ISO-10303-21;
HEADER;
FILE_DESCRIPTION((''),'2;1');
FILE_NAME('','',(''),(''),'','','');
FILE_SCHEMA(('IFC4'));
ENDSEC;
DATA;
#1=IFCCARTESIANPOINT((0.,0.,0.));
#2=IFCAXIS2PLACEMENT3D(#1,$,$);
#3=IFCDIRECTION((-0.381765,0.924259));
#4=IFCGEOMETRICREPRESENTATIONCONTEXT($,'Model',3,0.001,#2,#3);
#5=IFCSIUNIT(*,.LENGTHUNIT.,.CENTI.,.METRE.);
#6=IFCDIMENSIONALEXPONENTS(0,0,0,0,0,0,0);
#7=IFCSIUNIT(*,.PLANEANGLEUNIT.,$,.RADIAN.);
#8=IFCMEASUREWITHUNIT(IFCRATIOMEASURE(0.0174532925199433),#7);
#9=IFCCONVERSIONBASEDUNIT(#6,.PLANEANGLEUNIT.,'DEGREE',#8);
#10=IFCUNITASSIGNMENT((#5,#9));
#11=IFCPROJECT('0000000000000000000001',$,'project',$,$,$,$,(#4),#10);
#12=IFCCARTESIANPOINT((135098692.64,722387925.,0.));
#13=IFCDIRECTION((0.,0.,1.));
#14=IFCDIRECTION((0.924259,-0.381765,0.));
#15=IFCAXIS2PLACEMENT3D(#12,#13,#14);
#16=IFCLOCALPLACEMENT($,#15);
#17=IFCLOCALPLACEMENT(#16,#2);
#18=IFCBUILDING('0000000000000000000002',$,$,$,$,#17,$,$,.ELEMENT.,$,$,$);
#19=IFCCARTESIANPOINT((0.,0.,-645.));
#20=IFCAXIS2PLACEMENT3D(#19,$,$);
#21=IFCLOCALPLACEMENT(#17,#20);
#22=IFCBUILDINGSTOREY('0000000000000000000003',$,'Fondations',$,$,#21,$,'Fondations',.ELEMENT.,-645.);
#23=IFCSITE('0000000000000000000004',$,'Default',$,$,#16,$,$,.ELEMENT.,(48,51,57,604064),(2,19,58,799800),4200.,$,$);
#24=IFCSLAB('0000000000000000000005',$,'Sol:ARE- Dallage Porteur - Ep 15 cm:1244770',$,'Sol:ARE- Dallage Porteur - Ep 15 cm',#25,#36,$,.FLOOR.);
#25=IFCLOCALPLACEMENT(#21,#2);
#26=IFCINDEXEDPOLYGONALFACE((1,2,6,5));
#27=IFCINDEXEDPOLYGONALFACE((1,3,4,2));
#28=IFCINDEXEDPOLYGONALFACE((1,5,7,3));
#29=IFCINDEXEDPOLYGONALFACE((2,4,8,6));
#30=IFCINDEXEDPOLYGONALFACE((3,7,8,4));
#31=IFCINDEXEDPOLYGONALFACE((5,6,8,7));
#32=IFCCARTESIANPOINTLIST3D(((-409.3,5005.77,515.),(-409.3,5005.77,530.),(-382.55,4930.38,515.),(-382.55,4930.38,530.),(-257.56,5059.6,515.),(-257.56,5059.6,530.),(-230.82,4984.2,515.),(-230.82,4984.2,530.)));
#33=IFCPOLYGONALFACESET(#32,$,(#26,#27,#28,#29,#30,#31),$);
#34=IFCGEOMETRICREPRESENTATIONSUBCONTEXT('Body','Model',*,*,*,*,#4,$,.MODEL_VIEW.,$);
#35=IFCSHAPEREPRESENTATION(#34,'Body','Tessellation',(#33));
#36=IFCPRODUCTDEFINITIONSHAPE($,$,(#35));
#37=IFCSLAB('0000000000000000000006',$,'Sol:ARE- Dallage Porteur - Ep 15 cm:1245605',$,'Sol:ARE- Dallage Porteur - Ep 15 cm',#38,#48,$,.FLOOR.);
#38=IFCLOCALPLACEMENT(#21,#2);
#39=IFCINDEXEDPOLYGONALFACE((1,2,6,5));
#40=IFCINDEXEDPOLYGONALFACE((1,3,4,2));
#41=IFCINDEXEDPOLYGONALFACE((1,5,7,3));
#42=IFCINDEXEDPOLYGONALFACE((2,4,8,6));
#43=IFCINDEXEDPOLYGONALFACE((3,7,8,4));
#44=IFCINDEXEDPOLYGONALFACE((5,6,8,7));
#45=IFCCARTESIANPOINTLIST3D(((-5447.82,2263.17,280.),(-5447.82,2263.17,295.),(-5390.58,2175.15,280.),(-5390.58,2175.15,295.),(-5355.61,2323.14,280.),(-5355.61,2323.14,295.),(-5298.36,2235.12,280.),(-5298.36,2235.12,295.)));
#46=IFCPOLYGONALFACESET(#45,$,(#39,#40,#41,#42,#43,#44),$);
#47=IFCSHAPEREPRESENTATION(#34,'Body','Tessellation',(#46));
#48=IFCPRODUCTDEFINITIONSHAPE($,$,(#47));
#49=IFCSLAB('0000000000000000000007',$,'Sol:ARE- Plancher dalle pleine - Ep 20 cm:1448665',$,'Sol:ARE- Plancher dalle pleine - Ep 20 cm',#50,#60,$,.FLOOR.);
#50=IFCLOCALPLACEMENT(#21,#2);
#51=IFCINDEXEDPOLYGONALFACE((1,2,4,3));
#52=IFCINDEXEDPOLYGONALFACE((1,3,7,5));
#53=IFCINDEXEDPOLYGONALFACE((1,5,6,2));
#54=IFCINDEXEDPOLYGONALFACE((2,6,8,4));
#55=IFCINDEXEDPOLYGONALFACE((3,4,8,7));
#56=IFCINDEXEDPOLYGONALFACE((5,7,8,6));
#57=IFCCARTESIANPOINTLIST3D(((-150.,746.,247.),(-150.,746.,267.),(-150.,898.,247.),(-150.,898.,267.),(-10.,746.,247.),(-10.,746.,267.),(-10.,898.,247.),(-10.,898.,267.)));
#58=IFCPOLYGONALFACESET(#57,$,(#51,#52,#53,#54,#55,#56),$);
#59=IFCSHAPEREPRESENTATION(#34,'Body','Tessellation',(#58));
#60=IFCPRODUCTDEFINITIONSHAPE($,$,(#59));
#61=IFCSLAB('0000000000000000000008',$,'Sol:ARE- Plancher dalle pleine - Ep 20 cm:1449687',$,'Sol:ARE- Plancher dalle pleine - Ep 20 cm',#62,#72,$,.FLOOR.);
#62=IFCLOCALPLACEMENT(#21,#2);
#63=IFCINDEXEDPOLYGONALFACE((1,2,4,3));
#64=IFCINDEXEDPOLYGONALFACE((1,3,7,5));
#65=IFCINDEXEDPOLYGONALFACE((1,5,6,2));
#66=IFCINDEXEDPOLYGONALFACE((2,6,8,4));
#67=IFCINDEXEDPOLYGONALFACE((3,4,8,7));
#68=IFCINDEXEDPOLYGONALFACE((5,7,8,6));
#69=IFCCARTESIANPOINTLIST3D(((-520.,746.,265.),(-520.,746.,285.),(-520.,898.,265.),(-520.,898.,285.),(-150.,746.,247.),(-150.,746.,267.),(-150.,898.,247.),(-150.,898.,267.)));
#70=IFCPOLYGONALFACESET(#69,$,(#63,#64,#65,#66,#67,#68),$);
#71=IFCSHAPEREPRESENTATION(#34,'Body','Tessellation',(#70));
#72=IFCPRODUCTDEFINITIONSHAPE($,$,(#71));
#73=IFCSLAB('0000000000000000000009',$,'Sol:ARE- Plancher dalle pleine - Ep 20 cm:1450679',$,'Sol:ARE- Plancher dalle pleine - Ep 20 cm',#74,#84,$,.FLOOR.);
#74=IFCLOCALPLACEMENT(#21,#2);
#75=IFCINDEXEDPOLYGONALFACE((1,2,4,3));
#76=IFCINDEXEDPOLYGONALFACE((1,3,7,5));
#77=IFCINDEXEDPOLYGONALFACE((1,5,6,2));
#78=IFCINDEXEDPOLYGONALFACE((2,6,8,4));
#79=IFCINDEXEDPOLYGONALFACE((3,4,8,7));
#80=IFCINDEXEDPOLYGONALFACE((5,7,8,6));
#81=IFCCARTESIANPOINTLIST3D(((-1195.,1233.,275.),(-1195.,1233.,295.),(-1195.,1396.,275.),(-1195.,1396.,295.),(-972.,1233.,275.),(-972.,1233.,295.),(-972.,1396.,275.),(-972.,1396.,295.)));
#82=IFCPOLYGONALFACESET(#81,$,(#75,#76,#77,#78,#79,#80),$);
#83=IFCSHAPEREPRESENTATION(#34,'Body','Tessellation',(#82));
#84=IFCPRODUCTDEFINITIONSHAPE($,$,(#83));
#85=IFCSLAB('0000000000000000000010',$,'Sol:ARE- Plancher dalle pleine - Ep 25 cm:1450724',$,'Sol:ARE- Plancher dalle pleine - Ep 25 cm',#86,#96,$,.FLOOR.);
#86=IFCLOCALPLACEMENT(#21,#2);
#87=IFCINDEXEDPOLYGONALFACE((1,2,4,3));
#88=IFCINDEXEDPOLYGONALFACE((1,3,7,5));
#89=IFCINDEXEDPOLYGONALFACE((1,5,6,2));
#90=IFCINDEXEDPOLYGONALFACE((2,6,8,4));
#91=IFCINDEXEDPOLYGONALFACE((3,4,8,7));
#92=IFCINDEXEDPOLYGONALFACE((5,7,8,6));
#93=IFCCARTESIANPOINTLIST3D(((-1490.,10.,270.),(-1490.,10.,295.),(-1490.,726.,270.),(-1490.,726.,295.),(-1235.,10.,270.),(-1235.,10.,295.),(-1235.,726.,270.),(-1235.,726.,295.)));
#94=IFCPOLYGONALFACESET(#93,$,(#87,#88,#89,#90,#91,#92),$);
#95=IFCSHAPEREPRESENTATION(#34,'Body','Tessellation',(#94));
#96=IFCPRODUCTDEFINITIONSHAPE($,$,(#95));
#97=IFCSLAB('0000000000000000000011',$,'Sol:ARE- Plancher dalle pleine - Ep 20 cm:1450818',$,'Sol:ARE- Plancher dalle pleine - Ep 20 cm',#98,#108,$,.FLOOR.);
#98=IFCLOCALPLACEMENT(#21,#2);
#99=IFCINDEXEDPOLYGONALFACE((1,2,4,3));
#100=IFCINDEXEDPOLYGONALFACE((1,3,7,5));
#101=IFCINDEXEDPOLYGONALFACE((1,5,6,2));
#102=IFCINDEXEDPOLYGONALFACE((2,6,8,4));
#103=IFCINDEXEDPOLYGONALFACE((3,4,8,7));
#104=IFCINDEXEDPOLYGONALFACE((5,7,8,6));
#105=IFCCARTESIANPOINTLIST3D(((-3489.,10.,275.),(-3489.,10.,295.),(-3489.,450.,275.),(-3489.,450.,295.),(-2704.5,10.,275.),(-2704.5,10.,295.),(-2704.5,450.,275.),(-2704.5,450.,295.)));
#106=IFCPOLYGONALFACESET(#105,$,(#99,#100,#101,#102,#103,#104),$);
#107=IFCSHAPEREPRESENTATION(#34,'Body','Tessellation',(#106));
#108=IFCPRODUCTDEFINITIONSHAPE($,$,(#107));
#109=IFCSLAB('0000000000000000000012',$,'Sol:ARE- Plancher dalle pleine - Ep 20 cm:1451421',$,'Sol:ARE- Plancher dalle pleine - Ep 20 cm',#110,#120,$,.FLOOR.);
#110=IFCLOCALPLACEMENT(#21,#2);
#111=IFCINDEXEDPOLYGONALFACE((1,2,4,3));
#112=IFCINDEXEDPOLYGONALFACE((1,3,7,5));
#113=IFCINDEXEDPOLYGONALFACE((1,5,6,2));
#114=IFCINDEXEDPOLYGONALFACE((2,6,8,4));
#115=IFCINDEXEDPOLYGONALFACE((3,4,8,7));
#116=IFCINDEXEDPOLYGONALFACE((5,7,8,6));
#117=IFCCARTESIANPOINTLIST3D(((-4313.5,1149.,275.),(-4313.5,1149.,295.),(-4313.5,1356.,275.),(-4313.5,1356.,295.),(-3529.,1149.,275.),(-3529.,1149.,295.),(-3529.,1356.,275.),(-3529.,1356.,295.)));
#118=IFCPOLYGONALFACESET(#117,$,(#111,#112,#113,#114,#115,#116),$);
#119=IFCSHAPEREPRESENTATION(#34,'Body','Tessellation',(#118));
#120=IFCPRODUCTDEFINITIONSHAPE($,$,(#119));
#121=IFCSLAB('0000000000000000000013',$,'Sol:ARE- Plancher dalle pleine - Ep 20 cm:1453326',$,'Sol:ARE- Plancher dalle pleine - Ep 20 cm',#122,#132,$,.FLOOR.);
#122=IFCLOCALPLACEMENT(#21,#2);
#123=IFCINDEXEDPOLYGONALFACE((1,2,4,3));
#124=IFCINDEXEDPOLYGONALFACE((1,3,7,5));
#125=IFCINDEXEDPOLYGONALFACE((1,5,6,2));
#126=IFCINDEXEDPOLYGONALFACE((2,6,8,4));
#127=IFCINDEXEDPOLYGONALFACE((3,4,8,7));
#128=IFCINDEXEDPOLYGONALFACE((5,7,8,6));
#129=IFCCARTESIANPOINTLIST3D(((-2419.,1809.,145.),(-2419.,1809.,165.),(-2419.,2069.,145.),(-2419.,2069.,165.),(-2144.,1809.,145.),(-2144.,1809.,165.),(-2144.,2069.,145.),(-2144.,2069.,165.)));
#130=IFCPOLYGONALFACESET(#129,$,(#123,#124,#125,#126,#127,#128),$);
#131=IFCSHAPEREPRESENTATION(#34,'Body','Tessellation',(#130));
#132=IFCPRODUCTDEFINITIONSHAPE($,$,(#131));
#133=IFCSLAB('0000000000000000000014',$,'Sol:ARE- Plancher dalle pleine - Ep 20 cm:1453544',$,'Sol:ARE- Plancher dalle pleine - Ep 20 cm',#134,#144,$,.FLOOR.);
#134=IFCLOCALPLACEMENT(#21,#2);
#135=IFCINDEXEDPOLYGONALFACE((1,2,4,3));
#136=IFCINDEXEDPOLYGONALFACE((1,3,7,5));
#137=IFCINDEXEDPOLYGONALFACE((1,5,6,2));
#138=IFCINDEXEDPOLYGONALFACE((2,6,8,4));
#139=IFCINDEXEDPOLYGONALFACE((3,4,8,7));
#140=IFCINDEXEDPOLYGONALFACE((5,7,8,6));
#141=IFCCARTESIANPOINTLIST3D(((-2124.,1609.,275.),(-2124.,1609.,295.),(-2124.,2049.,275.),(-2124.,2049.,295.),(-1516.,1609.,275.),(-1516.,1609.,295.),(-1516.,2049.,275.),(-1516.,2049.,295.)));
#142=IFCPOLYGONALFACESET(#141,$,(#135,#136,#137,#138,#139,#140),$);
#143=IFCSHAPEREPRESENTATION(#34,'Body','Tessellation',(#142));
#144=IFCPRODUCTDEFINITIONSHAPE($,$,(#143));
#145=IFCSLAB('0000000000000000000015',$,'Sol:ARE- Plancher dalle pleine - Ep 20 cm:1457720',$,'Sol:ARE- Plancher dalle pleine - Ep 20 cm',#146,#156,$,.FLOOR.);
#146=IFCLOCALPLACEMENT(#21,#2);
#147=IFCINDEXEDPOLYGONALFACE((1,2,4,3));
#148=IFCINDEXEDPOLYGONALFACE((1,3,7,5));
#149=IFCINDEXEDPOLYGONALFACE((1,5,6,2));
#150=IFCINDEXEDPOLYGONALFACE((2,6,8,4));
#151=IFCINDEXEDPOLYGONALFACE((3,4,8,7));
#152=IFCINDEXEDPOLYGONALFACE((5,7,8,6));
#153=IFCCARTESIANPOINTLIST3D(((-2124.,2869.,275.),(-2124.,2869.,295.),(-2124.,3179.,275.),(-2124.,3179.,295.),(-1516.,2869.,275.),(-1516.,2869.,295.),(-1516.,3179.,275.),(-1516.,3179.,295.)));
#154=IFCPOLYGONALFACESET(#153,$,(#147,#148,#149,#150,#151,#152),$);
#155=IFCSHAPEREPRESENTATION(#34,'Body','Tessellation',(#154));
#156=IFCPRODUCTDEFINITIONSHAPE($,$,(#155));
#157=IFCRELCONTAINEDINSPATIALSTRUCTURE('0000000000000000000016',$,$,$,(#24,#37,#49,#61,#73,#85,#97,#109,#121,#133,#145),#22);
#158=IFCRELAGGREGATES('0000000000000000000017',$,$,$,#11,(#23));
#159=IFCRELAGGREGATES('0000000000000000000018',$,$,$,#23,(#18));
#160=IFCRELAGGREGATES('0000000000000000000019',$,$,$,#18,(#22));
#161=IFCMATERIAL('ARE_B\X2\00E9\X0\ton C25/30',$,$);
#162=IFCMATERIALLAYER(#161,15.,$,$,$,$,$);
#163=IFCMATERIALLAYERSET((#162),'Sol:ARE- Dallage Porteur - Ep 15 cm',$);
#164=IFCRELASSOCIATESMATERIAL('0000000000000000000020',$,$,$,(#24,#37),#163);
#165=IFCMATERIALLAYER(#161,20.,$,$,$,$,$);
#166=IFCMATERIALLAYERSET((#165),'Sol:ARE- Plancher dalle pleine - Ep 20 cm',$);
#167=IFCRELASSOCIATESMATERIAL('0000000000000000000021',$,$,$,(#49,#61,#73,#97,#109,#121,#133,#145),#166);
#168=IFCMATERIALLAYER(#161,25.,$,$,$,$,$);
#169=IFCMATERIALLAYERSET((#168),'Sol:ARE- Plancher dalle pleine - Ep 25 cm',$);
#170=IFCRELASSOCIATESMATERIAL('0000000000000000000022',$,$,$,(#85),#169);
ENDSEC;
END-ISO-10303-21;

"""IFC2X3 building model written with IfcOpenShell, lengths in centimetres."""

from ifc_helpers import new_model, entity, si_unit, converted_unit, direction, frame, frame_2d, origin, origin_2d_with_axis, place, context, subcontext, project, spatial, rectangle, extrude, clip, halfspace, material, layer, layer_set, layer_usage, element, save


model = new_model("IFC2X3")

# Units and contexts
model_context = context("Model", 3, precision=0.001, world=origin(), true_north=direction((-0.381765, 0.924259)))
body_context = subcontext(model_context, "Body", "Model", "MODEL_VIEW")
ifc_project = project(units=[si_unit("LENGTHUNIT", "METRE", prefix="CENTI"), converted_unit("PLANEANGLEUNIT", "DEGREE", entity("IfcRatioMeasure", 0.0174532925199433), si_unit("PLANEANGLEUNIT", "RADIAN"), dimensions=[0, 0, 0, 0, 0, 0, 0])], contexts=[model_context])

# Site, building, storey
site_placement = place(None, frame((135098692.64, 722387925.0, 0.0), z_axis=(0.0, 0.0, 1.0), x_axis=(0.924259, -0.381765, 0.0)))
site = spatial("IfcSite", under=ifc_project, at=site_placement, Name="Default", CompositionType="ELEMENT", RefLatitude=(48, 51, 57, 604064), RefLongitude=(2, 19, 58, 799800), RefElevation=4200.0)
building_placement = place(site_placement, origin())
building = spatial("IfcBuilding", under=site, at=building_placement, CompositionType="ELEMENT")
storey_placement = place(building_placement, frame((0.0, 0.0, -645.0)))
storey = spatial("IfcBuildingStorey", under=building, at=storey_placement, Name="Fondations", LongName="Fondations", CompositionType="ELEMENT", Elevation=-645.0)

# Slabs
ifc_material = material(Name="ARE_Béton C25/30")
ifc_layer_1 = layer(ifc_material, 15.0)
ifc_layer_set_1 = layer_set([ifc_layer_1], Name="Sol:ARE- Dallage Porteur - Ep 15 cm")
ifc_layer_usage_1 = layer_usage(ifc_layer_set_1, "AXIS3", "POSITIVE", 0.0)
slab_1_placement = place(storey_placement, origin())
element("IfcSlab", 1, at=slab_1_placement, inside=storey, material=ifc_layer_usage_1, Name="Sol:ARE- Dallage Porteur - Ep 15 cm:1244770", ObjectType="Sol:ARE- Dallage Porteur - Ep 15 cm", PredefinedType="FLOOR", context=body_context, shape_type="SweptSolid", body=[
    extrude(rectangle(XDim=80.0, YDim=161.0, at=frame_2d((0.0, 0.0), x_axis=(1.0, 0.0))), frame((-320.06, 4994.99, 530.0), z_axis=(0.0, 0.0, -1.0), x_axis=(0.334331, -0.942456, 0.0)), (0.0, 0.0, 1.0), 15.0),
])
ifc_layer_usage_2 = layer_usage(ifc_layer_set_1, "AXIS3", "POSITIVE", 0.0)
slab_2_placement = place(storey_placement, origin())
element("IfcSlab", 2, at=slab_2_placement, inside=storey, material=ifc_layer_usage_2, Name="Sol:ARE- Dallage Porteur - Ep 15 cm:1245605", ObjectType="Sol:ARE- Dallage Porteur - Ep 15 cm", PredefinedType="FLOOR", context=body_context, shape_type="SweptSolid", body=[
    extrude(rectangle(XDim=105.0, YDim=110.0, at=origin_2d_with_axis()), frame((-5373.09, 2249.14, 295.0), z_axis=(0.0, 0.0, -1.0), x_axis=(0.545236, -0.838282, 0.0)), (0.0, 0.0, 1.0), 15.0),
])
ifc_layer_2 = layer(ifc_material, 20.0)
ifc_layer_set_2 = layer_set([ifc_layer_2], Name="Sol:ARE- Plancher dalle pleine - Ep 20 cm")
ifc_layer_usage_3 = layer_usage(ifc_layer_set_2, "AXIS3", "POSITIVE", 0.0)
slab_3_placement = place(storey_placement, origin())
element("IfcSlab", 3, at=slab_3_placement, inside=storey, material=ifc_layer_usage_3, Name="Sol:ARE- Plancher dalle pleine - Ep 20 cm:1448665", ObjectType="Sol:ARE- Plancher dalle pleine - Ep 20 cm", PredefinedType="FLOOR", context=body_context, shape_type="SweptSolid", body=[
    extrude(rectangle(XDim=152.0, YDim=140.0, at=frame_2d((0.0, 0.0), x_axis=(1.0, 0.0))), frame((-80.0, 822.0, 267.0), z_axis=(0.0, 0.0, -1.0), x_axis=(0.0, 1.0, 0.0)), (0.0, 0.0, 1.0), 20.0),
])
ifc_layer_usage_4 = layer_usage(ifc_layer_set_2, "AXIS3", "POSITIVE", 0.0)
slab_4_placement = place(storey_placement, origin())
element("IfcSlab", 4, at=slab_4_placement, inside=storey, material=ifc_layer_usage_4, Name="Sol:ARE- Plancher dalle pleine - Ep 20 cm:1449687", ObjectType="Sol:ARE- Plancher dalle pleine - Ep 20 cm", PredefinedType="FLOOR", context=body_context, shape_type="Clipping", body=[
    clip(clip(extrude(rectangle(XDim=370.44, YDim=152.0, at=frame_2d((0.0, 0.0), x_axis=(0.0, 1.0))), frame((-335.0, 822.0, 276.0), z_axis=(-0.048591, 0.0, -0.998819), x_axis=(0.0, 1.0, 0.0)), (0.0, 0.048591, 0.998819), 20.02), halfspace(frame((-335.0, 822.0, 256.0), z_axis=(-0.048591, 0.0, -0.998819), x_axis=(0.0, -1.0, 0.0)), False)), halfspace(frame((-335.0, 822.0, 276.0), z_axis=(0.048591, 0.0, 0.998819), x_axis=(0.0, -1.0, 0.0)), False)),
])
ifc_layer_usage_5 = layer_usage(ifc_layer_set_2, "AXIS3", "POSITIVE", 0.0)
slab_5_placement = place(storey_placement, origin())
element("IfcSlab", 5, at=slab_5_placement, inside=storey, material=ifc_layer_usage_5, Name="Sol:ARE- Plancher dalle pleine - Ep 20 cm:1450679", ObjectType="Sol:ARE- Plancher dalle pleine - Ep 20 cm", PredefinedType="FLOOR", context=body_context, shape_type="SweptSolid", body=[
    extrude(rectangle(XDim=163.0, YDim=223.0, at=frame_2d((0.0, 0.0), x_axis=(1.0, 0.0))), frame((-1083.5, 1314.5, 295.0), z_axis=(0.0, 0.0, -1.0), x_axis=(0.0, 1.0, 0.0)), (0.0, 0.0, 1.0), 20.0),
])
ifc_layer_3 = layer(ifc_material, 25.0)
ifc_layer_set_3 = layer_set([ifc_layer_3], Name="Sol:ARE- Plancher dalle pleine - Ep 25 cm")
ifc_layer_usage_6 = layer_usage(ifc_layer_set_3, "AXIS3", "POSITIVE", 0.0)
slab_6_placement = place(storey_placement, origin())
element("IfcSlab", 6, at=slab_6_placement, inside=storey, material=ifc_layer_usage_6, Name="Sol:ARE- Plancher dalle pleine - Ep 25 cm:1450724", ObjectType="Sol:ARE- Plancher dalle pleine - Ep 25 cm", PredefinedType="FLOOR", context=body_context, shape_type="SweptSolid", body=[
    extrude(rectangle(XDim=716.0, YDim=255.0, at=frame_2d((0.0, 0.0), x_axis=(1.0, 0.0))), frame((-1362.5, 368.0, 295.0), z_axis=(0.0, 0.0, -1.0), x_axis=(0.0, 1.0, 0.0)), (0.0, 0.0, 1.0), 25.0),
])
ifc_layer_usage_7 = layer_usage(ifc_layer_set_2, "AXIS3", "POSITIVE", 0.0)
slab_7_placement = place(storey_placement, origin())
element("IfcSlab", 7, at=slab_7_placement, inside=storey, material=ifc_layer_usage_7, Name="Sol:ARE- Plancher dalle pleine - Ep 20 cm:1450818", ObjectType="Sol:ARE- Plancher dalle pleine - Ep 20 cm", PredefinedType="FLOOR", context=body_context, shape_type="SweptSolid", body=[
    extrude(rectangle(XDim=440.0, YDim=784.5, at=frame_2d((0.0, 0.0), x_axis=(1.0, 0.0))), frame((-3096.75, 230.0, 295.0), z_axis=(0.0, 0.0, -1.0), x_axis=(0.0, 1.0, 0.0)), (0.0, 0.0, 1.0), 20.0),
])
ifc_layer_usage_8 = layer_usage(ifc_layer_set_2, "AXIS3", "POSITIVE", 0.0)
slab_8_placement = place(storey_placement, origin())
element("IfcSlab", 8, at=slab_8_placement, inside=storey, material=ifc_layer_usage_8, Name="Sol:ARE- Plancher dalle pleine - Ep 20 cm:1451421", ObjectType="Sol:ARE- Plancher dalle pleine - Ep 20 cm", PredefinedType="FLOOR", context=body_context, shape_type="SweptSolid", body=[
    extrude(rectangle(XDim=207.0, YDim=784.5, at=frame_2d((0.0, 0.0), x_axis=(1.0, 0.0))), frame((-3921.25, 1252.5, 295.0), z_axis=(0.0, 0.0, -1.0), x_axis=(0.0, 1.0, 0.0)), (0.0, 0.0, 1.0), 20.0),
])
ifc_layer_usage_9 = layer_usage(ifc_layer_set_2, "AXIS3", "POSITIVE", 0.0)
slab_9_placement = place(storey_placement, origin())
element("IfcSlab", 9, at=slab_9_placement, inside=storey, material=ifc_layer_usage_9, Name="Sol:ARE- Plancher dalle pleine - Ep 20 cm:1453326", ObjectType="Sol:ARE- Plancher dalle pleine - Ep 20 cm", PredefinedType="FLOOR", context=body_context, shape_type="SweptSolid", body=[
    extrude(rectangle(XDim=260.0, YDim=275.0, at=frame_2d((0.0, 0.0), x_axis=(1.0, 0.0))), frame((-2281.5, 1939.0, 165.0), z_axis=(0.0, 0.0, -1.0), x_axis=(0.0, 1.0, 0.0)), (0.0, 0.0, 1.0), 20.0),
])
ifc_layer_usage_10 = layer_usage(ifc_layer_set_2, "AXIS3", "POSITIVE", 0.0)
slab_10_placement = place(storey_placement, origin())
element("IfcSlab", 10, at=slab_10_placement, inside=storey, material=ifc_layer_usage_10, Name="Sol:ARE- Plancher dalle pleine - Ep 20 cm:1453544", ObjectType="Sol:ARE- Plancher dalle pleine - Ep 20 cm", PredefinedType="FLOOR", context=body_context, shape_type="SweptSolid", body=[
    extrude(rectangle(XDim=440.0, YDim=608.0, at=frame_2d((0.0, 0.0), x_axis=(1.0, 0.0))), frame((-1820.0, 1829.0, 295.0), z_axis=(0.0, 0.0, -1.0), x_axis=(0.0, 1.0, 0.0)), (0.0, 0.0, 1.0), 20.0),
])
ifc_layer_usage_11 = layer_usage(ifc_layer_set_2, "AXIS3", "POSITIVE", 0.0)
slab_11_placement = place(storey_placement, origin())
element("IfcSlab", 11, at=slab_11_placement, inside=storey, material=ifc_layer_usage_11, Name="Sol:ARE- Plancher dalle pleine - Ep 20 cm:1457720", ObjectType="Sol:ARE- Plancher dalle pleine - Ep 20 cm", PredefinedType="FLOOR", context=body_context, shape_type="SweptSolid", body=[
    extrude(rectangle(XDim=310.0, YDim=608.0, at=frame_2d((0.0, 0.0), x_axis=(1.0, 0.0))), frame((-1820.0, 3024.0, 295.0), z_axis=(0.0, 0.0, -1.0), x_axis=(0.0, 1.0, 0.0)), (0.0, 0.0, 1.0), 20.0),
])

save(model, "model.ifc")
